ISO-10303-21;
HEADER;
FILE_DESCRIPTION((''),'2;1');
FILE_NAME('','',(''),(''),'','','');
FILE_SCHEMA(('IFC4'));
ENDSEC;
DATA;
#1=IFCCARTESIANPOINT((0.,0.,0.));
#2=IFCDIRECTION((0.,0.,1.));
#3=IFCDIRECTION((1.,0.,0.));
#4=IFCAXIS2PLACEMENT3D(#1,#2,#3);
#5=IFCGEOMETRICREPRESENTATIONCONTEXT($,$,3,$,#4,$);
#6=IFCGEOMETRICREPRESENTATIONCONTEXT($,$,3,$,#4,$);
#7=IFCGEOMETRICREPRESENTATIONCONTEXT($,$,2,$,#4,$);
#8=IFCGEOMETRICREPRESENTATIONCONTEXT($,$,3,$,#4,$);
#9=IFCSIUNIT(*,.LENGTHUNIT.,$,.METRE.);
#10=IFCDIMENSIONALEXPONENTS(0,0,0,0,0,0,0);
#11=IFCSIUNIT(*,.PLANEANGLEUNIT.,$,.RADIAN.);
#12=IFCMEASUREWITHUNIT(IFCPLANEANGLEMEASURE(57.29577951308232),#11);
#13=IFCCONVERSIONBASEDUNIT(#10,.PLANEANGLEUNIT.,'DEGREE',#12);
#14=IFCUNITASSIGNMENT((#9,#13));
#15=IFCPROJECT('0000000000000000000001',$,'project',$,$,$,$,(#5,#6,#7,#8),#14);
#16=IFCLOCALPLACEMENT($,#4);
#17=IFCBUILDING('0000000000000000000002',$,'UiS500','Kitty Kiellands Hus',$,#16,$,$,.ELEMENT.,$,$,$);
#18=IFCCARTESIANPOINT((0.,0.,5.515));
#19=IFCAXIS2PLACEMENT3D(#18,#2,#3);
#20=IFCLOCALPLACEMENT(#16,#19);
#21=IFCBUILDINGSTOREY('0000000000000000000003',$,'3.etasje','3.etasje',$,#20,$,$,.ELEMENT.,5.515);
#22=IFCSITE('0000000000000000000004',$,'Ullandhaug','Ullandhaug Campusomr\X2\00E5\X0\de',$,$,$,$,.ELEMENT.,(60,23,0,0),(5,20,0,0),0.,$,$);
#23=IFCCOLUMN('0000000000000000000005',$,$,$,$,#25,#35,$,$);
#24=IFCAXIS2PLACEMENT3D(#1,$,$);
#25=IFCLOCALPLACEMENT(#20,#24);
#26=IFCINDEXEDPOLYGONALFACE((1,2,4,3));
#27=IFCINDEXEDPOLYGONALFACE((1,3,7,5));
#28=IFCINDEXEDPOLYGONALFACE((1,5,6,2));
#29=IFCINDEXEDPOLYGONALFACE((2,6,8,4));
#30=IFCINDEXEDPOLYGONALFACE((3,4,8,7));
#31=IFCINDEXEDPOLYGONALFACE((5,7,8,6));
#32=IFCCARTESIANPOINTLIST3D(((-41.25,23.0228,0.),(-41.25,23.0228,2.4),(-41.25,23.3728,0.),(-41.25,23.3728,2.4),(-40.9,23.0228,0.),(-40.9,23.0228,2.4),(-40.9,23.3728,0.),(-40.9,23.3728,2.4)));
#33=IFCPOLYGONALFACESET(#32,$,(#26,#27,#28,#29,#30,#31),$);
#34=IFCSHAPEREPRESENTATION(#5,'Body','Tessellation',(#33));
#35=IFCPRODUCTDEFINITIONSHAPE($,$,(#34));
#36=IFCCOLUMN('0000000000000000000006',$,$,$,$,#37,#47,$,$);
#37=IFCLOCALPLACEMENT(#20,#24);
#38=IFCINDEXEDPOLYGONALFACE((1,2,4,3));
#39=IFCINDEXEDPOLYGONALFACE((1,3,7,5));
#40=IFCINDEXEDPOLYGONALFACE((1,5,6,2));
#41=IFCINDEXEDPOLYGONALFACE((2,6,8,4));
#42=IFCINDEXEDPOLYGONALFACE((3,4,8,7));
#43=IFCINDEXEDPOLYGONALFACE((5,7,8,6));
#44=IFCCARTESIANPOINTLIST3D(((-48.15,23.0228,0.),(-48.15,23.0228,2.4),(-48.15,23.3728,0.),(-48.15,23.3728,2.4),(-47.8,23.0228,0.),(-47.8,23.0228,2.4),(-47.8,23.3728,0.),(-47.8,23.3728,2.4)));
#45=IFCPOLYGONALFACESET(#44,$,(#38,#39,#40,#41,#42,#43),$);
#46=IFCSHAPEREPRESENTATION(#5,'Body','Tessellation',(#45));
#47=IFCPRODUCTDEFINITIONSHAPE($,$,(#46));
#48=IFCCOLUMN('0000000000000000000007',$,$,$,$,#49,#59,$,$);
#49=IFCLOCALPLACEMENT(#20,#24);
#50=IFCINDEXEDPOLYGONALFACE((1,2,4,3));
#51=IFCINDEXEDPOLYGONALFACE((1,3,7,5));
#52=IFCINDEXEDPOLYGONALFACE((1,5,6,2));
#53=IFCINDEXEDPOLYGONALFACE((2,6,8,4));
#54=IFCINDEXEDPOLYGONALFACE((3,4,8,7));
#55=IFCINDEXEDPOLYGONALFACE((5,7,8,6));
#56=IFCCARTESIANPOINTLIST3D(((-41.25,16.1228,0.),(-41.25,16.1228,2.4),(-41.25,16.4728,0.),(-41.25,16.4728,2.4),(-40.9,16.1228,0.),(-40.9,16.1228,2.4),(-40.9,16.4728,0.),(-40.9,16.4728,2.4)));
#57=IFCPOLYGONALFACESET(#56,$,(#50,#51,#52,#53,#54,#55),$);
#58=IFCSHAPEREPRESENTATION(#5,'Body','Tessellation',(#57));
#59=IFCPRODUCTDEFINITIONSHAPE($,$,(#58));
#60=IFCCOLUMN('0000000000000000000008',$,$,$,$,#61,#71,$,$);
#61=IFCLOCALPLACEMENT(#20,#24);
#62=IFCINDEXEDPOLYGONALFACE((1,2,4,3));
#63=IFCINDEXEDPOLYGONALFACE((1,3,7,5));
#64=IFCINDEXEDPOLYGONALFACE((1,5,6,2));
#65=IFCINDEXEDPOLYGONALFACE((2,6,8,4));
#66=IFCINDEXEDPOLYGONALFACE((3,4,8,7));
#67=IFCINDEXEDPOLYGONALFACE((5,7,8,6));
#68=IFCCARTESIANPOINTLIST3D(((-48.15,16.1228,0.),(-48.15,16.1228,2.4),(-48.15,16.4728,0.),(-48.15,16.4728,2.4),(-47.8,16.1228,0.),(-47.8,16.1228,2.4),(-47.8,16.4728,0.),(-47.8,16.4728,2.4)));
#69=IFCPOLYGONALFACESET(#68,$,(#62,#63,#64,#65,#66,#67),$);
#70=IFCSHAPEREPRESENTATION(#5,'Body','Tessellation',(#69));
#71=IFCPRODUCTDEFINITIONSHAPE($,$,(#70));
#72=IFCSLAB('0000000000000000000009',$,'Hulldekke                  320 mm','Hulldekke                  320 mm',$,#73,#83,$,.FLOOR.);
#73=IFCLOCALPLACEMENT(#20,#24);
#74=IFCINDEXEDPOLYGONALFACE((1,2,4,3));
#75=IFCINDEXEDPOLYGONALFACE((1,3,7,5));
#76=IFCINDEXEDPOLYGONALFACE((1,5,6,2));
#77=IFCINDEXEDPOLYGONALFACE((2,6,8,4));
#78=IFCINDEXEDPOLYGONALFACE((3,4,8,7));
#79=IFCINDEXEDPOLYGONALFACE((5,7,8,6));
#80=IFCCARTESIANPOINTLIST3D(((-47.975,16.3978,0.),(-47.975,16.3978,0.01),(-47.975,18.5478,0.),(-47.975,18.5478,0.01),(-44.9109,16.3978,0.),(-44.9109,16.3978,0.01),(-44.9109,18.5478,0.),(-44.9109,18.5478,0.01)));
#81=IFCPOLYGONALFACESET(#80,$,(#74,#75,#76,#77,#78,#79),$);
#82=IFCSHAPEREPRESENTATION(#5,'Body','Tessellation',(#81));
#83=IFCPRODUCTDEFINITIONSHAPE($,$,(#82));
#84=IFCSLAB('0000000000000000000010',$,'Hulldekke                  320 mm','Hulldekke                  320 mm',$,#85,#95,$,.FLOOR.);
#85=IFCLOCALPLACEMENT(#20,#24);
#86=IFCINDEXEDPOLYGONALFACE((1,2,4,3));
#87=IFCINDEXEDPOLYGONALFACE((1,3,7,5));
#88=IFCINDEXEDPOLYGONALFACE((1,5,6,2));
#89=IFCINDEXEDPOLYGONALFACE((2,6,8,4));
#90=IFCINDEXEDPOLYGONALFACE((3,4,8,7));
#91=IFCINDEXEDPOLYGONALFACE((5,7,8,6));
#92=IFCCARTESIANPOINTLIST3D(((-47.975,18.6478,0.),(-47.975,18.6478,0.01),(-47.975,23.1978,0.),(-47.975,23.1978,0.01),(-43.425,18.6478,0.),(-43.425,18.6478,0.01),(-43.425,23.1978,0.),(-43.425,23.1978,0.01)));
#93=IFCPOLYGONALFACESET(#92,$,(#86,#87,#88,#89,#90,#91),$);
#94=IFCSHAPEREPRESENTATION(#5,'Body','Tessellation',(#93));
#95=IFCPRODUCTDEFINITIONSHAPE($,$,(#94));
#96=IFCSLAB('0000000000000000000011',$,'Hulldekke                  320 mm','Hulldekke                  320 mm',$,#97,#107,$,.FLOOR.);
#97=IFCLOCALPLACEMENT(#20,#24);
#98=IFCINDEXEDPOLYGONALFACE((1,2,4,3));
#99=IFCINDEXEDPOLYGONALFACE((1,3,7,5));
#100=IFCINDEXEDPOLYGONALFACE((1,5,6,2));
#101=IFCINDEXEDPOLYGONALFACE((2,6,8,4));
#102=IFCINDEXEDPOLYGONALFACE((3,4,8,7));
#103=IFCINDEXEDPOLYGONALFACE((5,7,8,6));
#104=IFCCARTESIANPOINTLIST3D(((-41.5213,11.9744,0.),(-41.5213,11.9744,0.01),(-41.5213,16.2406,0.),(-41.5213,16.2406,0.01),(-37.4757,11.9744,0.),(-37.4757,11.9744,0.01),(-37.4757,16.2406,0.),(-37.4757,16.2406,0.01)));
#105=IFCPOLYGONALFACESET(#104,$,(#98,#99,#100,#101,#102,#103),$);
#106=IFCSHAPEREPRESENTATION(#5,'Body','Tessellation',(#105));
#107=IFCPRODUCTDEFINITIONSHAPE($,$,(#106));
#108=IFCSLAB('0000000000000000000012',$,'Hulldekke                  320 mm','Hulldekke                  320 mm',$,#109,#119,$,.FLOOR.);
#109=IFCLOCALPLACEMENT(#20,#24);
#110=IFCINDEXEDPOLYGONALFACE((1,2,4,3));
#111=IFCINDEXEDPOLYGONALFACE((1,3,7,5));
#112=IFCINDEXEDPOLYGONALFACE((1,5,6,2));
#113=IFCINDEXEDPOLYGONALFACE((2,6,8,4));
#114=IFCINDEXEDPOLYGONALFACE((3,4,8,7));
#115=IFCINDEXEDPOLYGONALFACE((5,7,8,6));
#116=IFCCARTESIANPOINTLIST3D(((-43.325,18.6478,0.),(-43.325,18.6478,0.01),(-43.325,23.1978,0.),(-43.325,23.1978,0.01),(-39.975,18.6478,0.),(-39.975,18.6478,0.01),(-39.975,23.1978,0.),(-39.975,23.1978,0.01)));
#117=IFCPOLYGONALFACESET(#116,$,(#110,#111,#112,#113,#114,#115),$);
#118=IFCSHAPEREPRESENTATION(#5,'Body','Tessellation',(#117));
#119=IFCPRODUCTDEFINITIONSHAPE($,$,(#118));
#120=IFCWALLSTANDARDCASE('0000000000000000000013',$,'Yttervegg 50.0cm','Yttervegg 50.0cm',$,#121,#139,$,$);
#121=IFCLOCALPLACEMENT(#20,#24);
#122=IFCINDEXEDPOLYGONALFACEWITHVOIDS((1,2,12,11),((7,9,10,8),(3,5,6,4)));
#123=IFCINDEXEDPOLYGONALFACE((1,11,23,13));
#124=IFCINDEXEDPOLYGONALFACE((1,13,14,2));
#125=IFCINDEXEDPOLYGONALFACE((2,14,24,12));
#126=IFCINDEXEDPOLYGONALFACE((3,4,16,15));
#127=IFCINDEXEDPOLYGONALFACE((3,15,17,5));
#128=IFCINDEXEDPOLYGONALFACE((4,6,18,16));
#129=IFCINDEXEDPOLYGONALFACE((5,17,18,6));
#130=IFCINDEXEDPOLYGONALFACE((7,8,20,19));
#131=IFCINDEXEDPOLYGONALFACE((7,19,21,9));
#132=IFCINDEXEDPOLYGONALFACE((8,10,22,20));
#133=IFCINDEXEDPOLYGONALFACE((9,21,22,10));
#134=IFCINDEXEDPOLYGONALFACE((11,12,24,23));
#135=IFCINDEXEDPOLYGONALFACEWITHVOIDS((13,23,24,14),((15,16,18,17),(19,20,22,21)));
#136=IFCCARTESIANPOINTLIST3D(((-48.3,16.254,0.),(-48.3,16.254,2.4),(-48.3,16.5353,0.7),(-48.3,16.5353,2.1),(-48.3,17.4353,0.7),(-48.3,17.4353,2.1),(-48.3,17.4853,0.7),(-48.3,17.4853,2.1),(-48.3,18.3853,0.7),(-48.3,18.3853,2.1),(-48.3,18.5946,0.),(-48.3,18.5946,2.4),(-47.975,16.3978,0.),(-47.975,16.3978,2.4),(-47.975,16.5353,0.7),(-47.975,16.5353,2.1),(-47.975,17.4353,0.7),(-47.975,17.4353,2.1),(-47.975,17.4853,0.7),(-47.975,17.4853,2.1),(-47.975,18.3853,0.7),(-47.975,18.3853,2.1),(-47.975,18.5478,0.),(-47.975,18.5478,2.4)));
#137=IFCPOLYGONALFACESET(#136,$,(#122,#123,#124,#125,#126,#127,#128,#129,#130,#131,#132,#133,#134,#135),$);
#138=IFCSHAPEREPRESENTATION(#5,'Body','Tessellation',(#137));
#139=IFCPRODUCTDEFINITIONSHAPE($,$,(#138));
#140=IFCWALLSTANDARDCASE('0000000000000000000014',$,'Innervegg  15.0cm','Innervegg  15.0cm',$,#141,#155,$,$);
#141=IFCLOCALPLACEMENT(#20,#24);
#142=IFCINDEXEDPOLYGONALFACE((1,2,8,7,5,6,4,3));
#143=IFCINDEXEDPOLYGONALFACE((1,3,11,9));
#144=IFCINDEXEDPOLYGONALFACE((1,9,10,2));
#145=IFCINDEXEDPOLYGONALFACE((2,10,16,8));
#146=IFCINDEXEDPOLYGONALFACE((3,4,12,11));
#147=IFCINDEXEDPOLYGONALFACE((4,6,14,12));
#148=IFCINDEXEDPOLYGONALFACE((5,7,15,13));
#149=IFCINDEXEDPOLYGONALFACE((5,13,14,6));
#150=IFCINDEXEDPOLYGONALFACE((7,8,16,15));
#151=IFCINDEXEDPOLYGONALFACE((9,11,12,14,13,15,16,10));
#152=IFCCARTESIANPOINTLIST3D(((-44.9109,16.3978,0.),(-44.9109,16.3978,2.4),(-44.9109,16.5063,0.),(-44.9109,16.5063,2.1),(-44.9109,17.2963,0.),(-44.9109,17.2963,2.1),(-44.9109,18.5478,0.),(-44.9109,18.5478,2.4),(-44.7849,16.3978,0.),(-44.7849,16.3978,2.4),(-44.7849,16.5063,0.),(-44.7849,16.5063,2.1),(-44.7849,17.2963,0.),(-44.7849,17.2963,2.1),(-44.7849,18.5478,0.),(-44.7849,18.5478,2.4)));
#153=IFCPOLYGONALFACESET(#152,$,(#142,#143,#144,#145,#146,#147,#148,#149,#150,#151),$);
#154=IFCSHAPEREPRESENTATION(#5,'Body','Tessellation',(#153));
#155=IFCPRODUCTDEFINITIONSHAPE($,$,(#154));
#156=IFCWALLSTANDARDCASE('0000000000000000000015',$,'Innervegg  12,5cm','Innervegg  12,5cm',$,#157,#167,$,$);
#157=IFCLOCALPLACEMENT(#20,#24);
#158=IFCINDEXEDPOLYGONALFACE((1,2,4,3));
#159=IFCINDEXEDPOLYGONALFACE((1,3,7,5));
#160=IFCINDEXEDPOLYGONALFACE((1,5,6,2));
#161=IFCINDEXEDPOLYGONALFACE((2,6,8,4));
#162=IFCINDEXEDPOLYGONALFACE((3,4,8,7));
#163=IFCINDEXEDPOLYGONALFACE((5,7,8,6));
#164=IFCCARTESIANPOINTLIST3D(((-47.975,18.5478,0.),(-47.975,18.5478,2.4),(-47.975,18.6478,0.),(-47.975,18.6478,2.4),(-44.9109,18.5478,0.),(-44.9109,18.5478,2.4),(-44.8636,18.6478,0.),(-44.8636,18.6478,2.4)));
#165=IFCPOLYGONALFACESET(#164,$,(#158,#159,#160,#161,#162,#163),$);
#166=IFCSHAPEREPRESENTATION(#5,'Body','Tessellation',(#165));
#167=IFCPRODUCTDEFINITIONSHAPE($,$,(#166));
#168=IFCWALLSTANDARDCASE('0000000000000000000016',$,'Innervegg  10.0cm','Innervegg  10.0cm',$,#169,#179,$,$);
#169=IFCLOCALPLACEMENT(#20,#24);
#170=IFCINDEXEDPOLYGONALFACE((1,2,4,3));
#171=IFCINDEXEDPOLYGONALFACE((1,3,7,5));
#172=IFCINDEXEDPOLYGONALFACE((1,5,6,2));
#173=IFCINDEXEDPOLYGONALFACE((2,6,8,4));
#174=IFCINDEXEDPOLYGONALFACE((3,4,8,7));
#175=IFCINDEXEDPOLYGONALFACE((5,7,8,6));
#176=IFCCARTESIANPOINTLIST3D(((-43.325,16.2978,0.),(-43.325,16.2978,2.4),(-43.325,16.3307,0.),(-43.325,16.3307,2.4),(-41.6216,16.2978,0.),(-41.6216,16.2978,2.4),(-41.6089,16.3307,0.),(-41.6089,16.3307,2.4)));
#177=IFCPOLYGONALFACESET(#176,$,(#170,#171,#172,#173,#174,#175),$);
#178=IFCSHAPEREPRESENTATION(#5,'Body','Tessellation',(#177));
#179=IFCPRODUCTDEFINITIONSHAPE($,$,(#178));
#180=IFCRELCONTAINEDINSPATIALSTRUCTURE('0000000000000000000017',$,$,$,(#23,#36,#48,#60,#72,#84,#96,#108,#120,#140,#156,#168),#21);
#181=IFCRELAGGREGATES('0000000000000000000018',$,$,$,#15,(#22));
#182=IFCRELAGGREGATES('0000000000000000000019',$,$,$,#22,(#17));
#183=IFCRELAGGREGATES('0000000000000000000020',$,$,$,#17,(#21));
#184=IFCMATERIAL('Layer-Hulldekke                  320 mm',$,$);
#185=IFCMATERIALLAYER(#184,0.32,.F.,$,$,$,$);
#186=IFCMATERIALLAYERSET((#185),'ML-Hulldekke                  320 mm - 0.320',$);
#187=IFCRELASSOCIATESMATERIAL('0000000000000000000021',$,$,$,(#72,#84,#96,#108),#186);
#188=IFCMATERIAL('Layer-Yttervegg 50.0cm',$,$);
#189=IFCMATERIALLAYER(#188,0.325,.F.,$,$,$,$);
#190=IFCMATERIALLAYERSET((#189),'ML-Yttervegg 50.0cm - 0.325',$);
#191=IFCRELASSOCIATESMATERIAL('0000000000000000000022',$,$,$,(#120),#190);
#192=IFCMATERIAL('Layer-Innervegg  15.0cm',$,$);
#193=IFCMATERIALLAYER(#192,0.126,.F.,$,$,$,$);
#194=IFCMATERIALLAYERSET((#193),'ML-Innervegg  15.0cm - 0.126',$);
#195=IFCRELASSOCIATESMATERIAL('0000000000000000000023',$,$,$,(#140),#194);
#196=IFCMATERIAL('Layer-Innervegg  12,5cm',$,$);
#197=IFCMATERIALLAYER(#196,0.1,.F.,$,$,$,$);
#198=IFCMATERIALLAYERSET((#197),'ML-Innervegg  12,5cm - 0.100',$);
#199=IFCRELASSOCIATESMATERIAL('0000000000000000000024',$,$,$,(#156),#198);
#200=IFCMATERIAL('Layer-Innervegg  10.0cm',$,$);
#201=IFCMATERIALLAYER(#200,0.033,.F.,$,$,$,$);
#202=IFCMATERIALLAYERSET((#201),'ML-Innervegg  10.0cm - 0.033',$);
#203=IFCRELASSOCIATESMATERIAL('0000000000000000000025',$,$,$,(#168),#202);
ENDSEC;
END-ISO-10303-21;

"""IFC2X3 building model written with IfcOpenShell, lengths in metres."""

from ifc_helpers import new_model, entity, si_unit, converted_unit, frame, origin_with_axes, origin_2d_with_axis, place, context, project, spatial, polyline, rectangle, outline, extrude, material, layer, layer_set, layer_usage, element, save


model = new_model("IFC2X3")

# Units and contexts
context_of_model_1 = context(None, 3, world=origin_with_axes())
context_of_model_2 = context(None, 3, world=origin_with_axes())
context_of_model_3 = context(None, 2, world=origin_with_axes())
context_of_model_4 = context(None, 3, world=origin_with_axes())
ifc_project = project(units=[si_unit("LENGTHUNIT", "METRE"), converted_unit("PLANEANGLEUNIT", "DEGREE", entity("IfcPlaneAngleMeasure", 57.29577951308232), si_unit("PLANEANGLEUNIT", "RADIAN"), dimensions=[0, 0, 0, 0, 0, 0, 0])], contexts=[context_of_model_1, context_of_model_2, context_of_model_3, context_of_model_4])

# Site, building, storey
site = spatial("IfcSite", under=ifc_project, Name="Ullandhaug", Description="Ullandhaug Campusområde", CompositionType="ELEMENT", RefLatitude=(60, 23, 0, 0), RefLongitude=(5, 20, 0, 0), RefElevation=0.0)
building_placement = place(None, origin_with_axes())
building = spatial("IfcBuilding", under=site, at=building_placement, Name="UiS500", Description="Kitty Kiellands Hus", CompositionType="ELEMENT")
storey_placement = place(building_placement, frame((0.0, 0.0, 5.515), z_axis=(0.0, 0.0, 1.0), x_axis=(1.0, 0.0, 0.0)))
storey = spatial("IfcBuildingStorey", under=building, at=storey_placement, Name="3.etasje", Description="3.etasje", CompositionType="ELEMENT", Elevation=5.515)

# Columns
for number, where, z_axis, x_axis in (
    (1, (-41.075, 23.1978, 0.0), (0.0, 0.0, 1.0), (1.0, 0.0, 0.0)),
    (2, (-47.975, 23.1978, 0.0), (0.0, 0.0, 1.0), (1.0, 0.0, 0.0)),
    (3, (-41.075, 16.2978, 0.0), (0.0, 0.0, 1.0), (1.0, 0.0, 0.0)),
    (4, (-47.975, 16.2978, 0.0), (0.0, 0.0, 1.0), (1.0, 0.0, 0.0)),
):
    element("IfcColumn", number, at=place(storey_placement, frame(where, z_axis=z_axis, x_axis=x_axis)), inside=storey, context=context_of_model_1, shape_type="SweptSolid", body=[
        extrude(rectangle(XDim=0.35, YDim=0.35, at=origin_2d_with_axis()), origin_with_axes(), (0.0, 0.0, 1.0), 2.4),
    ])

# Slabs
ifc_material_1 = material(Name="Layer-Hulldekke                  320 mm")
ifc_layer_1 = layer(ifc_material_1, 0.32, ventilated=False)
ifc_layer_set_1 = layer_set([ifc_layer_1], Name="ML-Hulldekke                  320 mm - 0.320")
ifc_layer_usage_1 = layer_usage(ifc_layer_set_1, "AXIS2", "POSITIVE", 0.0)
slab_1_placement = place(storey_placement, frame((-47.975, 18.5478, 0.0), z_axis=(0.0, 0.0, 1.0), x_axis=(1.0, 0.0, 0.0)))
element("IfcSlab", 5, at=slab_1_placement, inside=storey, material=ifc_layer_usage_1, Name="Hulldekke                  320 mm", Description="Hulldekke                  320 mm", PredefinedType="FLOOR", context=context_of_model_1, shape_type="SweptSolid", body=[
    extrude(outline(polyline([(0.0, 0.0), (2.15, 0.0), (2.15, 3.0641), (0.0, 3.0641), (0.0, 0.0)])), frame((0.0, 0.0, 0.0), z_axis=(0.0, 0.0, 1.0), x_axis=(0.0, -1.0, 0.0)), (0.0, 0.0, 1.0), 0.01),
])
slab_2_placement = place(storey_placement, frame((-47.975, 18.6478, 0.0), z_axis=(0.0, 0.0, 1.0), x_axis=(1.0, 0.0, 0.0)))
element("IfcSlab", 6, at=slab_2_placement, inside=storey, material=ifc_layer_usage_1, Name="Hulldekke                  320 mm", Description="Hulldekke                  320 mm", PredefinedType="FLOOR", context=context_of_model_1, shape_type="SweptSolid", body=[
    extrude(outline(polyline([(0.0, 0.0), (4.55, 0.0), (4.55, 4.55), (0.0, 4.55), (0.0, 0.0)])), origin_with_axes(), (0.0, 0.0, 1.0), 0.01),
])
slab_3_placement = place(storey_placement, frame((-41.5213, 16.2406, 0.0), z_axis=(0.0, 0.0, 1.0), x_axis=(1.0, 0.0, 0.0)))
element("IfcSlab", 7, at=slab_3_placement, inside=storey, material=ifc_layer_usage_1, Name="Hulldekke                  320 mm", Description="Hulldekke                  320 mm", PredefinedType="FLOOR", context=context_of_model_1, shape_type="SweptSolid", body=[
    extrude(outline(polyline([(0.0, 0.0), (4.2662, 0.0), (4.2662, 4.0455), (0.0, 4.0455), (0.0, 0.0)])), frame((0.0, 0.0, 0.0), z_axis=(0.0, 0.0, 1.0), x_axis=(0.0, -1.0, 0.0)), (0.0, 0.0, 1.0), 0.01),
])
slab_4_placement = place(storey_placement, frame((-43.325, 23.1978, 0.0), z_axis=(0.0, 0.0, 1.0), x_axis=(1.0, 0.0, 0.0)))
element("IfcSlab", 8, at=slab_4_placement, inside=storey, material=ifc_layer_usage_1, Name="Hulldekke                  320 mm", Description="Hulldekke                  320 mm", PredefinedType="FLOOR", context=context_of_model_1, shape_type="SweptSolid", body=[
    extrude(outline(polyline([(0.0, 0.0), (4.55, 0.0), (4.55, 3.35), (0.0, 3.35), (0.0, 0.0)])), frame((0.0, 0.0, 0.0), z_axis=(0.0, 0.0, 1.0), x_axis=(0.0, -1.0, 0.0)), (0.0, 0.0, 1.0), 0.01),
])

# Wall, openings
ifc_material_2 = material(Name="Layer-Yttervegg 50.0cm")
ifc_layer_2 = layer(ifc_material_2, 0.325, ventilated=False)
ifc_layer_set_2 = layer_set([ifc_layer_2], Name="ML-Yttervegg 50.0cm - 0.325")
ifc_layer_usage_2 = layer_usage(ifc_layer_set_2, "AXIS2", "POSITIVE", 0.0)
wall_1_placement = place(storey_placement, frame((-48.3, 18.5946, 0.0), z_axis=(0.0, 0.0, 1.0), x_axis=(0.0, -1.0, 0.0)))
wall_1 = element("IfcWallStandardCase", 9, at=wall_1_placement, inside=storey, material=ifc_layer_usage_2, Name="Yttervegg 50.0cm", Description="Yttervegg 50.0cm", context=context_of_model_1, shape_type="SweptSolid", body=[
    extrude(outline(polyline([(0.0, 0.0), (2.3406, 0.0), (2.1969, 0.325), (0.0469, 0.325), (0.0, 0.0)])), frame((0.0, 0.0, 0.0), z_axis=(0.0, 0.0, 1.0), x_axis=(1.0, 0.0, 0.0)), (0.0, 0.0, 1.0), 2.4),
])
opening_1_placement = place(wall_1_placement, frame((1.1594, 0.325, 0.7), z_axis=(0.0, 0.0, 1.0), x_axis=(1.0, 0.0, 0.0)))
element("IfcOpeningElement", 10, at=opening_1_placement, cuts=wall_1, context=context_of_model_1, shape_type="SweptSolid", body=[
    extrude(outline(polyline([(0.0, 0.0), (1.4, 0.0), (1.4, 0.9), (0.0, 0.9), (0.0, 0.0)])), frame((0.0, 0.0, 0.0), z_axis=(0.0, 1.0, 0.0), x_axis=(0.0, 0.0, 1.0)), (0.0, 0.0, -1.0), 0.325),
])
opening_2_placement = place(wall_1_placement, frame((0.2094, 0.325, 0.7), z_axis=(0.0, 0.0, 1.0), x_axis=(1.0, 0.0, 0.0)))
element("IfcOpeningElement", 11, at=opening_2_placement, cuts=wall_1, context=context_of_model_1, shape_type="SweptSolid", body=[
    extrude(outline(polyline([(0.0, 0.0), (1.4, 0.0), (1.4, 0.9), (0.0, 0.9), (0.0, 0.0)])), frame((0.0, 0.0, 0.0), z_axis=(0.0, 1.0, 0.0), x_axis=(0.0, 0.0, 1.0)), (0.0, 0.0, -1.0), 0.325),
])

# Wall, opening
ifc_material_3 = material(Name="Layer-Innervegg  15.0cm")
ifc_layer_3 = layer(ifc_material_3, 0.126, ventilated=False)
ifc_layer_set_3 = layer_set([ifc_layer_3], Name="ML-Innervegg  15.0cm - 0.126")
ifc_layer_usage_3 = layer_usage(ifc_layer_set_3, "AXIS2", "POSITIVE", 0.0)
wall_2_placement = place(storey_placement, frame((-44.7849, 16.3978, 0.0), z_axis=(0.0, 0.0, 1.0), x_axis=(0.0, 1.0, 0.0)))
wall_2 = element("IfcWallStandardCase", 12, at=wall_2_placement, inside=storey, material=ifc_layer_usage_3, Name="Innervegg  15.0cm", Description="Innervegg  15.0cm", context=context_of_model_1, shape_type="SweptSolid", body=[
    extrude(outline(polyline([(0.0, 0.0), (2.15, 0.0), (2.15, 0.126), (0.0, 0.126), (0.0, 0.0)])), frame((0.0, 0.0, 0.0), z_axis=(0.0, 0.0, 1.0), x_axis=(1.0, 0.0, 0.0)), (0.0, 0.0, 1.0), 2.4),
])
opening_3_placement = place(wall_2_placement, frame((0.1085, 0.126, 0.0), z_axis=(0.0, 0.0, 1.0), x_axis=(1.0, 0.0, 0.0)))
element("IfcOpeningElement", 13, at=opening_3_placement, cuts=wall_2, context=context_of_model_1, shape_type="SweptSolid", body=[
    extrude(outline(polyline([(0.0, 0.0), (2.1, 0.0), (2.1, 0.79), (0.0, 0.79), (0.0, 0.0)])), frame((0.0, 0.0, 0.0), z_axis=(0.0, 1.0, 0.0), x_axis=(0.0, 0.0, 1.0)), (0.0, 0.0, -1.0), 0.126),
])

# Walls
ifc_material_4 = material(Name="Layer-Innervegg  12,5cm")
ifc_layer_4 = layer(ifc_material_4, 0.1, ventilated=False)
ifc_layer_set_4 = layer_set([ifc_layer_4], Name="ML-Innervegg  12,5cm - 0.100")
ifc_layer_usage_4 = layer_usage(ifc_layer_set_4, "AXIS2", "POSITIVE", 0.0)
wall_3_placement = place(storey_placement, frame((-44.8636, 18.6478, 0.0), z_axis=(0.0, 0.0, 1.0), x_axis=(-1.0, 0.0, 0.0)))
element("IfcWallStandardCase", 14, at=wall_3_placement, inside=storey, material=ifc_layer_usage_4, Name="Innervegg  12,5cm", Description="Innervegg  12,5cm", context=context_of_model_1, shape_type="SweptSolid", body=[
    extrude(outline(polyline([(0.0, 0.0), (3.1114, 0.0), (3.1114, 0.1), (0.0473, 0.1), (0.0, 0.0)])), frame((0.0, 0.0, 0.0), z_axis=(0.0, 0.0, 1.0), x_axis=(1.0, 0.0, 0.0)), (0.0, 0.0, 1.0), 2.4),
])
ifc_material_5 = material(Name="Layer-Innervegg  10.0cm")
ifc_layer_5 = layer(ifc_material_5, 0.033, ventilated=False)
ifc_layer_set_5 = layer_set([ifc_layer_5], Name="ML-Innervegg  10.0cm - 0.033")
ifc_layer_usage_5 = layer_usage(ifc_layer_set_5, "AXIS2", "POSITIVE", 0.0)
wall_4_placement = place(storey_placement, frame((-41.6089, 16.3307, 0.0), z_axis=(0.0, 0.0, 1.0), x_axis=(-1.0, 0.0, 0.0)))
element("IfcWallStandardCase", 15, at=wall_4_placement, inside=storey, material=ifc_layer_usage_5, Name="Innervegg  10.0cm", Description="Innervegg  10.0cm", context=context_of_model_1, shape_type="SweptSolid", body=[
    extrude(outline(polyline([(0.0, 0.0), (1.7161, 0.0), (1.7161, 0.033), (0.0127, 0.033), (0.0, 0.0)])), frame((0.0, 0.0, 0.0), z_axis=(0.0, 0.0, 1.0), x_axis=(1.0, 0.0, 0.0)), (0.0, 0.0, 1.0), 2.4),
])

save(model, "model.ifc")
